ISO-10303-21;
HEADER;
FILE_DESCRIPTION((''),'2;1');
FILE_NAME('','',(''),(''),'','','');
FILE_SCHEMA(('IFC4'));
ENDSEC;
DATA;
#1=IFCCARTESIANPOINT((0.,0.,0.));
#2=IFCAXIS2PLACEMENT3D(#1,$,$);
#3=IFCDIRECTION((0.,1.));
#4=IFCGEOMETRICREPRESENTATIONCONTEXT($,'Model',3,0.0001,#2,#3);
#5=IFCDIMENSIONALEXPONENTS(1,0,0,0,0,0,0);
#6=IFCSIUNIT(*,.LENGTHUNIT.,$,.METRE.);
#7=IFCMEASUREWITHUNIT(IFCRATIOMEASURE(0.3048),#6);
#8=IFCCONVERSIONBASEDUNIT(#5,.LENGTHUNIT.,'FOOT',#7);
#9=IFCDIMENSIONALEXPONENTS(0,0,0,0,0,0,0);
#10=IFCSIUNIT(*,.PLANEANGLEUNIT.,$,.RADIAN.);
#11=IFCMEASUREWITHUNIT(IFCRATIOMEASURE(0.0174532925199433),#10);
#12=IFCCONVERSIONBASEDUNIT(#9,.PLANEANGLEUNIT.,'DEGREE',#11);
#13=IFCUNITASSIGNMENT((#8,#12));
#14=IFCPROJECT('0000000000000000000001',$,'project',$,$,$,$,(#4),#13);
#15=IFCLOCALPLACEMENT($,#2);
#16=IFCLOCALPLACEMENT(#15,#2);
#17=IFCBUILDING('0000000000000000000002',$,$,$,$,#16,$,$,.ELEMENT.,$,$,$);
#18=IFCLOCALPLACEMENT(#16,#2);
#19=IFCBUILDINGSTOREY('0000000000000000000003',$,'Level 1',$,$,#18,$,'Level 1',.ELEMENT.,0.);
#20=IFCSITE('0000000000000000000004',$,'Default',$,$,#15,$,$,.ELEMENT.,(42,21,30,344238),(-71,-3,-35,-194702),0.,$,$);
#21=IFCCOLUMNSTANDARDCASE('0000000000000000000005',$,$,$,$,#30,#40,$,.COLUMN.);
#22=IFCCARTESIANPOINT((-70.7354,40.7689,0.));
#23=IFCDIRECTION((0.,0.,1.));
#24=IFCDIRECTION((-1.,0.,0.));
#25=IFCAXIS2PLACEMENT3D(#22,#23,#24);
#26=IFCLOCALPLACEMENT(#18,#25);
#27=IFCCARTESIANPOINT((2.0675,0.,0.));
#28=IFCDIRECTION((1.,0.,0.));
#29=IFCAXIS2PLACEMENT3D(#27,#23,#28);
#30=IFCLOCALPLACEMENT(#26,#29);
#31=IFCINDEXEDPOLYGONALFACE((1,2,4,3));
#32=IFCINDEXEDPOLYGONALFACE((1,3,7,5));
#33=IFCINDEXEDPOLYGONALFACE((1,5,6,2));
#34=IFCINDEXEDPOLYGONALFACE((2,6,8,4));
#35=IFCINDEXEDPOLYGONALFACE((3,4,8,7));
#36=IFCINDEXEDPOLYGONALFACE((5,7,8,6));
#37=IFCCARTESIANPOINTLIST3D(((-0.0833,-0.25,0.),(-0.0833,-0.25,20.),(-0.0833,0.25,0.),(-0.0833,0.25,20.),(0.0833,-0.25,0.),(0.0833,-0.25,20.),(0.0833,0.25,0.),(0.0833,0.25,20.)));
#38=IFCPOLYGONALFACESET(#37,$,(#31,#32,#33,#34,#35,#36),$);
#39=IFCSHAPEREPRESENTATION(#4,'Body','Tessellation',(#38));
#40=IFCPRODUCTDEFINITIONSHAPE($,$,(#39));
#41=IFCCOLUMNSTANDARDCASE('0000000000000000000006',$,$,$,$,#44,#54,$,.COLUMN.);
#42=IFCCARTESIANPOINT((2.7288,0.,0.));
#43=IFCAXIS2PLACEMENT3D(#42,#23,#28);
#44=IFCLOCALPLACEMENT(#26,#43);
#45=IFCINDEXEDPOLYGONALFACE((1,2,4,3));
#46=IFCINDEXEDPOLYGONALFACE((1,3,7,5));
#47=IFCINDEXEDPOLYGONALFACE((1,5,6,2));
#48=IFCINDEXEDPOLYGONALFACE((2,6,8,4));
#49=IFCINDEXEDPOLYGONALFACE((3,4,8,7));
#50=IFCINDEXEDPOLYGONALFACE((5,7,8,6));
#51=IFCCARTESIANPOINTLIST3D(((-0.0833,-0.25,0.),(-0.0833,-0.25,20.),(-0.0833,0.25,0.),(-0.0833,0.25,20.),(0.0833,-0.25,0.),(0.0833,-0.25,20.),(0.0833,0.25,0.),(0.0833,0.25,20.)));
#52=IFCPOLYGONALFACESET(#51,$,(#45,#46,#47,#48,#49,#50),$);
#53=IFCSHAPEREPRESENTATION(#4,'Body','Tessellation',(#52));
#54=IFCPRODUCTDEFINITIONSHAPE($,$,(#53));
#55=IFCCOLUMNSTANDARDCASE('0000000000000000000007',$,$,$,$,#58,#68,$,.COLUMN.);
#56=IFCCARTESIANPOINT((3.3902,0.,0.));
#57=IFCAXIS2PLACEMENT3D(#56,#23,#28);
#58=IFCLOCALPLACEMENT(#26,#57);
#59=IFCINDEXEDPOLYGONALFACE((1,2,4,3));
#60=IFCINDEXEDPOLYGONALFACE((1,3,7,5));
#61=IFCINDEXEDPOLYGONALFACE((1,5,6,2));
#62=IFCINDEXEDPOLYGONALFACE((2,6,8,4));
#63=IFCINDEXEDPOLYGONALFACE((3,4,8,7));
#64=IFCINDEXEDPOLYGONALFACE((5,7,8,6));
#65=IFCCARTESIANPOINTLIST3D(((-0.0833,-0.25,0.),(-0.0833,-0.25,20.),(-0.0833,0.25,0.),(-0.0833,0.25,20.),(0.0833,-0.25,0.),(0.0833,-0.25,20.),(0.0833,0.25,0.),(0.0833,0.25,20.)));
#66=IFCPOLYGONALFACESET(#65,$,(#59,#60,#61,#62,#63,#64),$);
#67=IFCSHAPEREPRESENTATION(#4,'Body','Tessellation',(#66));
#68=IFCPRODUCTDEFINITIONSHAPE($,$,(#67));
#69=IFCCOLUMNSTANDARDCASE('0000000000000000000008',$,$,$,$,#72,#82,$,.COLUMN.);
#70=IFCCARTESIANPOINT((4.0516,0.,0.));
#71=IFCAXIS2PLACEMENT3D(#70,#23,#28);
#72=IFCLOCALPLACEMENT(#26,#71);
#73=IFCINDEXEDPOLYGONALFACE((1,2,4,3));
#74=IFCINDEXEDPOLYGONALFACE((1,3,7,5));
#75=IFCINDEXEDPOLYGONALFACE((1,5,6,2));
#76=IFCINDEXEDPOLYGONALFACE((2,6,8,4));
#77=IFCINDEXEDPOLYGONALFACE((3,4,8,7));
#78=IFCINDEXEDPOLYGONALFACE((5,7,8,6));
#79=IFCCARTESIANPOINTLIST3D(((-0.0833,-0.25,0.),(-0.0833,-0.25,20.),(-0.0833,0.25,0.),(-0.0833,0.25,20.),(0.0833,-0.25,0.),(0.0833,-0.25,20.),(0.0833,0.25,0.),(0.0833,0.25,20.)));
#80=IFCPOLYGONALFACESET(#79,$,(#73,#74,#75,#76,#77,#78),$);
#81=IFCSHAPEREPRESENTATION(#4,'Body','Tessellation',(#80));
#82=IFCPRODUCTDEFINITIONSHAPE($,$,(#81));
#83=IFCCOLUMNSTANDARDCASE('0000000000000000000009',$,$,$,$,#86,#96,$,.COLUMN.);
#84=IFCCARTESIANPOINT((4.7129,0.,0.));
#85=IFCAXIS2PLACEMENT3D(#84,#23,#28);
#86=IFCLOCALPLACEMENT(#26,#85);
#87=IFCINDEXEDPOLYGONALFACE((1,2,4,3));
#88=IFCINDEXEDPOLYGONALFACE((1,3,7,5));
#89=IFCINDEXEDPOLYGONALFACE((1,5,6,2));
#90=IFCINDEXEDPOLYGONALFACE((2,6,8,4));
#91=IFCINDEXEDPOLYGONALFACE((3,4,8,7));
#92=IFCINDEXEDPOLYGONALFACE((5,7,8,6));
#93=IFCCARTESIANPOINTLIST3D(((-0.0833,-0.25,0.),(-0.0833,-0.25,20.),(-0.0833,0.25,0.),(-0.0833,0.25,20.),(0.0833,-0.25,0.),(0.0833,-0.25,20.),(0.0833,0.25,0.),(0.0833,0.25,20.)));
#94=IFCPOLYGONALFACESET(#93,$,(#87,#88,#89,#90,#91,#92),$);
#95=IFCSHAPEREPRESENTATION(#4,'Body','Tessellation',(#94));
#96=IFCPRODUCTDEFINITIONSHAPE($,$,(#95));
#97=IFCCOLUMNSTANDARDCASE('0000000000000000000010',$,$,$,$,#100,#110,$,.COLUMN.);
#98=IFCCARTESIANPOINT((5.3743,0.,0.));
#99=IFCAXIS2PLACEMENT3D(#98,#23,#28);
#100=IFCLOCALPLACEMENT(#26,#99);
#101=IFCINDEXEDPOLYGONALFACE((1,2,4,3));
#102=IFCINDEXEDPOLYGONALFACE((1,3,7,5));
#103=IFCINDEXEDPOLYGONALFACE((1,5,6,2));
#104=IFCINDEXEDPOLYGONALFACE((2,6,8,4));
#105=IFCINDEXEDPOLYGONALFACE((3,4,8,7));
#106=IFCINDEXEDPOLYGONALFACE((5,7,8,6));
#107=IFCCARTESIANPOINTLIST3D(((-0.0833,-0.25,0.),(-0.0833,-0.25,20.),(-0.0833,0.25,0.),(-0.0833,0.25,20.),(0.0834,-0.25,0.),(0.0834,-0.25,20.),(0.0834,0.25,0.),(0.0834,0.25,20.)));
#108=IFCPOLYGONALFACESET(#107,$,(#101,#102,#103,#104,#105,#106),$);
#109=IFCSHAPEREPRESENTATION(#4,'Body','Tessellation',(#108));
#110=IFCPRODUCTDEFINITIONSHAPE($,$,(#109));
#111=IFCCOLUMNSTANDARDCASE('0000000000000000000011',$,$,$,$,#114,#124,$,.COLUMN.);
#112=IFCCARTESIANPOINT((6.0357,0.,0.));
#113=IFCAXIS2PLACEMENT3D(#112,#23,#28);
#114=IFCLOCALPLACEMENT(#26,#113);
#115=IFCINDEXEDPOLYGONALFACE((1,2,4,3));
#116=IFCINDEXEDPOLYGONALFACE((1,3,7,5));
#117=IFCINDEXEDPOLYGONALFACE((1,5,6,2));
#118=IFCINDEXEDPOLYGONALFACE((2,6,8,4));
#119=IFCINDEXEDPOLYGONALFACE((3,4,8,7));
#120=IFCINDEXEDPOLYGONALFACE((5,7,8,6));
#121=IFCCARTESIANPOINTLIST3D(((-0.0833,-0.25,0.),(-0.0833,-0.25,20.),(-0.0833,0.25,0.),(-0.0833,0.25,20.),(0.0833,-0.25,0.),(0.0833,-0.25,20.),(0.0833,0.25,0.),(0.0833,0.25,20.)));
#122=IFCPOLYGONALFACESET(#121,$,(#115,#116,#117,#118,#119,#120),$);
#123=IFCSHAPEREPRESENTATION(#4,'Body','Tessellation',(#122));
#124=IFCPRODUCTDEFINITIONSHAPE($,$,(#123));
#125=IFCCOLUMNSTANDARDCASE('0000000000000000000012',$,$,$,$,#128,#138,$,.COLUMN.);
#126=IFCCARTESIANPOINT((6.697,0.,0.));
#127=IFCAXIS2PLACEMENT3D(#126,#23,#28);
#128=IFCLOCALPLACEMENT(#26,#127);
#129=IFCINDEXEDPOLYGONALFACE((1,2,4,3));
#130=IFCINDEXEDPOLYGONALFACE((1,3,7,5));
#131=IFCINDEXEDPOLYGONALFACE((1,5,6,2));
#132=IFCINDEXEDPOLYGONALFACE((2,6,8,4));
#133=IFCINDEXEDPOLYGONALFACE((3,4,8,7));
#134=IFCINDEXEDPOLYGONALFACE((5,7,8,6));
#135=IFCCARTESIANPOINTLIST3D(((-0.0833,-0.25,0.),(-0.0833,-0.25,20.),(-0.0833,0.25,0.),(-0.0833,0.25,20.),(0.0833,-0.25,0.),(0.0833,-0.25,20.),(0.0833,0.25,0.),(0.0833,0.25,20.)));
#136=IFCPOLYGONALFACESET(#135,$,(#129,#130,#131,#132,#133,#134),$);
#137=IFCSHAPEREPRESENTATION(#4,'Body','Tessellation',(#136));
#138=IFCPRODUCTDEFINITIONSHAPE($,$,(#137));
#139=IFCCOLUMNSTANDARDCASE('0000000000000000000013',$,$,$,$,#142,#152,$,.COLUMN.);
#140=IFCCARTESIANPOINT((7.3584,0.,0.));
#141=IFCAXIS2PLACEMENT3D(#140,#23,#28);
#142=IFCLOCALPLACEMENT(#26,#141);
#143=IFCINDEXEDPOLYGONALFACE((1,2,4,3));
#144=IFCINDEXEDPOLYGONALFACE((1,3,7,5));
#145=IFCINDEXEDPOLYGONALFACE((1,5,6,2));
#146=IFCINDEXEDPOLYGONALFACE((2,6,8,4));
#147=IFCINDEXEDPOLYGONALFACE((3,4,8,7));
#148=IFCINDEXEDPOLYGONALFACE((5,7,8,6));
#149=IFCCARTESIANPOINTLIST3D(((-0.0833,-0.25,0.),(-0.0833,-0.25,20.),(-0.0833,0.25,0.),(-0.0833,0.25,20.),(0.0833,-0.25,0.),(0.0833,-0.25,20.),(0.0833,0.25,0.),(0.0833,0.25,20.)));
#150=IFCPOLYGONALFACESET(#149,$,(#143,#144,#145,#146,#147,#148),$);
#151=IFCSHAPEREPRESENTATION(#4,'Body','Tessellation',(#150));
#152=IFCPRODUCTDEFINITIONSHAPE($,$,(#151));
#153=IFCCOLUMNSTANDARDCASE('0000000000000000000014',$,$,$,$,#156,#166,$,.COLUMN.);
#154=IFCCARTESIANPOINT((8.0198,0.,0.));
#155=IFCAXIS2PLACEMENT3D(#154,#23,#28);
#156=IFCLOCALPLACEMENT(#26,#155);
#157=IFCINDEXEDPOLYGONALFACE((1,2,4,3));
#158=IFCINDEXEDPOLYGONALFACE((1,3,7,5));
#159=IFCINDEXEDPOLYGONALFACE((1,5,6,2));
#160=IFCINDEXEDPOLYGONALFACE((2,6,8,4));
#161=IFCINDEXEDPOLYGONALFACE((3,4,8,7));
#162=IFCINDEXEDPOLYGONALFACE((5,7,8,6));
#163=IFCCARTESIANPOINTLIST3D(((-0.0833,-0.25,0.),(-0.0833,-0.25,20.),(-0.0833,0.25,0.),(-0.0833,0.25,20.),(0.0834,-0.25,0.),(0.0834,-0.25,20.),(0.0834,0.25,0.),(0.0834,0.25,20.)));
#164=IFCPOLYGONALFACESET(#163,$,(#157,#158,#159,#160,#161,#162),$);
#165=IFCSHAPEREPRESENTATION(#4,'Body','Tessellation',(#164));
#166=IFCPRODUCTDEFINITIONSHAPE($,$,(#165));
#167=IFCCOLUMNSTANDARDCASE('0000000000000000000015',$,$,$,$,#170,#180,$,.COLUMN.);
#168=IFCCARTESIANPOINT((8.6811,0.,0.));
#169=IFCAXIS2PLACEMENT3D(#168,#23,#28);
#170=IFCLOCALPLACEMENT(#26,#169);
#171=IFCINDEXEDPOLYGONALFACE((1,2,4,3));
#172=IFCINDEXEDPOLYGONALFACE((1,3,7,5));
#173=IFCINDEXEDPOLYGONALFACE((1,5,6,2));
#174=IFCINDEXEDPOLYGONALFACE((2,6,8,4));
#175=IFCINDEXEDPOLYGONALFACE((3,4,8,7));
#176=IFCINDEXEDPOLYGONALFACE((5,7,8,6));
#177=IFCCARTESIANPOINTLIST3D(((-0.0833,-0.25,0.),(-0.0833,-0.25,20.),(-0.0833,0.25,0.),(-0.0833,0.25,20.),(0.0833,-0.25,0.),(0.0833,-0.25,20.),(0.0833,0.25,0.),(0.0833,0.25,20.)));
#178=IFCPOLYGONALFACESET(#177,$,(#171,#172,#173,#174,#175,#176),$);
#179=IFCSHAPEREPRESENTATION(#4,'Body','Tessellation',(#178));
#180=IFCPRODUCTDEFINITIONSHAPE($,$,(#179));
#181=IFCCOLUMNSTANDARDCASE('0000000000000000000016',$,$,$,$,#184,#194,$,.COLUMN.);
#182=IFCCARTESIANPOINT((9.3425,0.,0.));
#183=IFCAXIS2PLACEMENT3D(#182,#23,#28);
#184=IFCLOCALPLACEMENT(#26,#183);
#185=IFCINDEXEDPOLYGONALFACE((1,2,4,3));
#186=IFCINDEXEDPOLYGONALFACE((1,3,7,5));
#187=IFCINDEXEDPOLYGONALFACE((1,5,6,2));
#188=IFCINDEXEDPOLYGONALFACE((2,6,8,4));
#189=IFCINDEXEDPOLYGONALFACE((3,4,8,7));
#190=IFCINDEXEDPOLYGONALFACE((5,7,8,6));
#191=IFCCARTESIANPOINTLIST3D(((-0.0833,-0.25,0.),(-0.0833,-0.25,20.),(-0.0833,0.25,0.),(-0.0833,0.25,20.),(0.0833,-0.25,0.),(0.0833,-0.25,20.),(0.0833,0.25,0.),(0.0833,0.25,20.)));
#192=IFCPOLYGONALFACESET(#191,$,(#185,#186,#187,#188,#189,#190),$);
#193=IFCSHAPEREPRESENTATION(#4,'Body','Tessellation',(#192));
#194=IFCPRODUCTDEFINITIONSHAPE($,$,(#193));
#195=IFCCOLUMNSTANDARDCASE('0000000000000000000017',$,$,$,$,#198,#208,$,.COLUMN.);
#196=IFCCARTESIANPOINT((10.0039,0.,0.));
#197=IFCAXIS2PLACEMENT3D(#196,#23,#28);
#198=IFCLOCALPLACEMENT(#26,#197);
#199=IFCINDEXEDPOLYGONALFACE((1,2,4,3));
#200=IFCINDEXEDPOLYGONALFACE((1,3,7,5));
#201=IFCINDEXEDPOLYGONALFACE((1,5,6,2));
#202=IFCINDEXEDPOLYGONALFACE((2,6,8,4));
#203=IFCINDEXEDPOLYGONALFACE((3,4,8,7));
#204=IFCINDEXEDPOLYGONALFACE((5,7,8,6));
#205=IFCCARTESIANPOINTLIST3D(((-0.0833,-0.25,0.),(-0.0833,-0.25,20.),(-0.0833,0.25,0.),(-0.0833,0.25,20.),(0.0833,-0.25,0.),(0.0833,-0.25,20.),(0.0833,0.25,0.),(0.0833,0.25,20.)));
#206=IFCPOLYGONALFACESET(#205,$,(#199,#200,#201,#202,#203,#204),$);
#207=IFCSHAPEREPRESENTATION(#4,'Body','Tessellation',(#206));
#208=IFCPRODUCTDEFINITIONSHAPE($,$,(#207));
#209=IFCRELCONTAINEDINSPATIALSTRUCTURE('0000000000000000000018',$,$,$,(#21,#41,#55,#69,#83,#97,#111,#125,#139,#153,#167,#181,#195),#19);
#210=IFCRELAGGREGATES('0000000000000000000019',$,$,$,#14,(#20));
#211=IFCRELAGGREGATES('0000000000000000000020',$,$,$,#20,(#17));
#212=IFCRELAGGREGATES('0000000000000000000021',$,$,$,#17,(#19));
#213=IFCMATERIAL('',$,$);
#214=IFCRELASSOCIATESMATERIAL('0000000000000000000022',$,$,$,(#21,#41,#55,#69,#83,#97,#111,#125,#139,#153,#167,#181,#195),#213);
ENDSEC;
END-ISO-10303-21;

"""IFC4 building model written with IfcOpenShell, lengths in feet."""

from ifc_helpers import new_model, entity, si_unit, converted_unit, direction, frame, origin, place, context, project, spatial, rectangle, extrude, material, element, save


model = new_model("IFC4")

# Units and contexts
model_context = context("Model", 3, precision=0.0001, world=origin(), true_north=direction((0.0, 1.0)))
ifc_project = project(units=[converted_unit("LENGTHUNIT", "FOOT", entity("IfcRatioMeasure", 0.3048), si_unit("LENGTHUNIT", "METRE"), dimensions=[1, 0, 0, 0, 0, 0, 0]), converted_unit("PLANEANGLEUNIT", "DEGREE", entity("IfcRatioMeasure", 0.0174532925199433), si_unit("PLANEANGLEUNIT", "RADIAN"), dimensions=[0, 0, 0, 0, 0, 0, 0])], contexts=[model_context])

# Site, building, storey
site_placement = place(None, origin())
site = spatial("IfcSite", under=ifc_project, at=site_placement, Name="Default", CompositionType="ELEMENT", RefLatitude=(42, 21, 30, 344238), RefLongitude=(-71, -3, -35, -194702), RefElevation=0.0)
building_placement = place(site_placement, origin())
building = spatial("IfcBuilding", under=site, at=building_placement, CompositionType="ELEMENT")
storey_placement = place(building_placement, origin())
storey = spatial("IfcBuildingStorey", under=building, at=storey_placement, Name="Level 1", LongName="Level 1", CompositionType="ELEMENT", Elevation=0.0)

# Columns
ifc_material_1 = material(Name="")
wall_1_placement = place(storey_placement, frame((-70.7354, 40.7689, 0.0), z_axis=(0.0, 0.0, 1.0), x_axis=(-1.0, 0.0, 0.0)))
for number, where, z_axis, x_axis in (
    (1, (2.0675, 0.0, 0.0), (0.0, 0.0, 1.0), (1.0, 0.0, 0.0)),
    (2, (2.7288, 0.0, 0.0), (0.0, 0.0, 1.0), (1.0, 0.0, 0.0)),
    (3, (3.3902, 0.0, 0.0), (0.0, 0.0, 1.0), (1.0, 0.0, 0.0)),
    (4, (4.0516, 0.0, 0.0), (0.0, 0.0, 1.0), (1.0, 0.0, 0.0)),
    (5, (4.7129, 0.0, 0.0), (0.0, 0.0, 1.0), (1.0, 0.0, 0.0)),
    (6, (5.3743, 0.0, 0.0), (0.0, 0.0, 1.0), (1.0, 0.0, 0.0)),
    (7, (6.0357, 0.0, 0.0), (0.0, 0.0, 1.0), (1.0, 0.0, 0.0)),
    (8, (6.697, 0.0, 0.0), (0.0, 0.0, 1.0), (1.0, 0.0, 0.0)),
    (9, (7.3584, 0.0, 0.0), (0.0, 0.0, 1.0), (1.0, 0.0, 0.0)),
    (10, (8.0198, 0.0, 0.0), (0.0, 0.0, 1.0), (1.0, 0.0, 0.0)),
    (11, (8.6811, 0.0, 0.0), (0.0, 0.0, 1.0), (1.0, 0.0, 0.0)),
    (12, (9.3425, 0.0, 0.0), (0.0, 0.0, 1.0), (1.0, 0.0, 0.0)),
    (13, (10.0039, 0.0, 0.0), (0.0, 0.0, 1.0), (1.0, 0.0, 0.0)),
):
    element("IfcColumnStandardCase", number, at=place(wall_1_placement, frame(where, z_axis=z_axis, x_axis=x_axis)), inside=storey, material=ifc_material_1, PredefinedType="COLUMN", context=model_context, shape_type="SweptSolid", body=[
        extrude(rectangle(XDim=0.1667, YDim=0.5), origin(), (0.0, 0.0, 1.0), 20.0),
    ])

save(model, "model.ifc")
